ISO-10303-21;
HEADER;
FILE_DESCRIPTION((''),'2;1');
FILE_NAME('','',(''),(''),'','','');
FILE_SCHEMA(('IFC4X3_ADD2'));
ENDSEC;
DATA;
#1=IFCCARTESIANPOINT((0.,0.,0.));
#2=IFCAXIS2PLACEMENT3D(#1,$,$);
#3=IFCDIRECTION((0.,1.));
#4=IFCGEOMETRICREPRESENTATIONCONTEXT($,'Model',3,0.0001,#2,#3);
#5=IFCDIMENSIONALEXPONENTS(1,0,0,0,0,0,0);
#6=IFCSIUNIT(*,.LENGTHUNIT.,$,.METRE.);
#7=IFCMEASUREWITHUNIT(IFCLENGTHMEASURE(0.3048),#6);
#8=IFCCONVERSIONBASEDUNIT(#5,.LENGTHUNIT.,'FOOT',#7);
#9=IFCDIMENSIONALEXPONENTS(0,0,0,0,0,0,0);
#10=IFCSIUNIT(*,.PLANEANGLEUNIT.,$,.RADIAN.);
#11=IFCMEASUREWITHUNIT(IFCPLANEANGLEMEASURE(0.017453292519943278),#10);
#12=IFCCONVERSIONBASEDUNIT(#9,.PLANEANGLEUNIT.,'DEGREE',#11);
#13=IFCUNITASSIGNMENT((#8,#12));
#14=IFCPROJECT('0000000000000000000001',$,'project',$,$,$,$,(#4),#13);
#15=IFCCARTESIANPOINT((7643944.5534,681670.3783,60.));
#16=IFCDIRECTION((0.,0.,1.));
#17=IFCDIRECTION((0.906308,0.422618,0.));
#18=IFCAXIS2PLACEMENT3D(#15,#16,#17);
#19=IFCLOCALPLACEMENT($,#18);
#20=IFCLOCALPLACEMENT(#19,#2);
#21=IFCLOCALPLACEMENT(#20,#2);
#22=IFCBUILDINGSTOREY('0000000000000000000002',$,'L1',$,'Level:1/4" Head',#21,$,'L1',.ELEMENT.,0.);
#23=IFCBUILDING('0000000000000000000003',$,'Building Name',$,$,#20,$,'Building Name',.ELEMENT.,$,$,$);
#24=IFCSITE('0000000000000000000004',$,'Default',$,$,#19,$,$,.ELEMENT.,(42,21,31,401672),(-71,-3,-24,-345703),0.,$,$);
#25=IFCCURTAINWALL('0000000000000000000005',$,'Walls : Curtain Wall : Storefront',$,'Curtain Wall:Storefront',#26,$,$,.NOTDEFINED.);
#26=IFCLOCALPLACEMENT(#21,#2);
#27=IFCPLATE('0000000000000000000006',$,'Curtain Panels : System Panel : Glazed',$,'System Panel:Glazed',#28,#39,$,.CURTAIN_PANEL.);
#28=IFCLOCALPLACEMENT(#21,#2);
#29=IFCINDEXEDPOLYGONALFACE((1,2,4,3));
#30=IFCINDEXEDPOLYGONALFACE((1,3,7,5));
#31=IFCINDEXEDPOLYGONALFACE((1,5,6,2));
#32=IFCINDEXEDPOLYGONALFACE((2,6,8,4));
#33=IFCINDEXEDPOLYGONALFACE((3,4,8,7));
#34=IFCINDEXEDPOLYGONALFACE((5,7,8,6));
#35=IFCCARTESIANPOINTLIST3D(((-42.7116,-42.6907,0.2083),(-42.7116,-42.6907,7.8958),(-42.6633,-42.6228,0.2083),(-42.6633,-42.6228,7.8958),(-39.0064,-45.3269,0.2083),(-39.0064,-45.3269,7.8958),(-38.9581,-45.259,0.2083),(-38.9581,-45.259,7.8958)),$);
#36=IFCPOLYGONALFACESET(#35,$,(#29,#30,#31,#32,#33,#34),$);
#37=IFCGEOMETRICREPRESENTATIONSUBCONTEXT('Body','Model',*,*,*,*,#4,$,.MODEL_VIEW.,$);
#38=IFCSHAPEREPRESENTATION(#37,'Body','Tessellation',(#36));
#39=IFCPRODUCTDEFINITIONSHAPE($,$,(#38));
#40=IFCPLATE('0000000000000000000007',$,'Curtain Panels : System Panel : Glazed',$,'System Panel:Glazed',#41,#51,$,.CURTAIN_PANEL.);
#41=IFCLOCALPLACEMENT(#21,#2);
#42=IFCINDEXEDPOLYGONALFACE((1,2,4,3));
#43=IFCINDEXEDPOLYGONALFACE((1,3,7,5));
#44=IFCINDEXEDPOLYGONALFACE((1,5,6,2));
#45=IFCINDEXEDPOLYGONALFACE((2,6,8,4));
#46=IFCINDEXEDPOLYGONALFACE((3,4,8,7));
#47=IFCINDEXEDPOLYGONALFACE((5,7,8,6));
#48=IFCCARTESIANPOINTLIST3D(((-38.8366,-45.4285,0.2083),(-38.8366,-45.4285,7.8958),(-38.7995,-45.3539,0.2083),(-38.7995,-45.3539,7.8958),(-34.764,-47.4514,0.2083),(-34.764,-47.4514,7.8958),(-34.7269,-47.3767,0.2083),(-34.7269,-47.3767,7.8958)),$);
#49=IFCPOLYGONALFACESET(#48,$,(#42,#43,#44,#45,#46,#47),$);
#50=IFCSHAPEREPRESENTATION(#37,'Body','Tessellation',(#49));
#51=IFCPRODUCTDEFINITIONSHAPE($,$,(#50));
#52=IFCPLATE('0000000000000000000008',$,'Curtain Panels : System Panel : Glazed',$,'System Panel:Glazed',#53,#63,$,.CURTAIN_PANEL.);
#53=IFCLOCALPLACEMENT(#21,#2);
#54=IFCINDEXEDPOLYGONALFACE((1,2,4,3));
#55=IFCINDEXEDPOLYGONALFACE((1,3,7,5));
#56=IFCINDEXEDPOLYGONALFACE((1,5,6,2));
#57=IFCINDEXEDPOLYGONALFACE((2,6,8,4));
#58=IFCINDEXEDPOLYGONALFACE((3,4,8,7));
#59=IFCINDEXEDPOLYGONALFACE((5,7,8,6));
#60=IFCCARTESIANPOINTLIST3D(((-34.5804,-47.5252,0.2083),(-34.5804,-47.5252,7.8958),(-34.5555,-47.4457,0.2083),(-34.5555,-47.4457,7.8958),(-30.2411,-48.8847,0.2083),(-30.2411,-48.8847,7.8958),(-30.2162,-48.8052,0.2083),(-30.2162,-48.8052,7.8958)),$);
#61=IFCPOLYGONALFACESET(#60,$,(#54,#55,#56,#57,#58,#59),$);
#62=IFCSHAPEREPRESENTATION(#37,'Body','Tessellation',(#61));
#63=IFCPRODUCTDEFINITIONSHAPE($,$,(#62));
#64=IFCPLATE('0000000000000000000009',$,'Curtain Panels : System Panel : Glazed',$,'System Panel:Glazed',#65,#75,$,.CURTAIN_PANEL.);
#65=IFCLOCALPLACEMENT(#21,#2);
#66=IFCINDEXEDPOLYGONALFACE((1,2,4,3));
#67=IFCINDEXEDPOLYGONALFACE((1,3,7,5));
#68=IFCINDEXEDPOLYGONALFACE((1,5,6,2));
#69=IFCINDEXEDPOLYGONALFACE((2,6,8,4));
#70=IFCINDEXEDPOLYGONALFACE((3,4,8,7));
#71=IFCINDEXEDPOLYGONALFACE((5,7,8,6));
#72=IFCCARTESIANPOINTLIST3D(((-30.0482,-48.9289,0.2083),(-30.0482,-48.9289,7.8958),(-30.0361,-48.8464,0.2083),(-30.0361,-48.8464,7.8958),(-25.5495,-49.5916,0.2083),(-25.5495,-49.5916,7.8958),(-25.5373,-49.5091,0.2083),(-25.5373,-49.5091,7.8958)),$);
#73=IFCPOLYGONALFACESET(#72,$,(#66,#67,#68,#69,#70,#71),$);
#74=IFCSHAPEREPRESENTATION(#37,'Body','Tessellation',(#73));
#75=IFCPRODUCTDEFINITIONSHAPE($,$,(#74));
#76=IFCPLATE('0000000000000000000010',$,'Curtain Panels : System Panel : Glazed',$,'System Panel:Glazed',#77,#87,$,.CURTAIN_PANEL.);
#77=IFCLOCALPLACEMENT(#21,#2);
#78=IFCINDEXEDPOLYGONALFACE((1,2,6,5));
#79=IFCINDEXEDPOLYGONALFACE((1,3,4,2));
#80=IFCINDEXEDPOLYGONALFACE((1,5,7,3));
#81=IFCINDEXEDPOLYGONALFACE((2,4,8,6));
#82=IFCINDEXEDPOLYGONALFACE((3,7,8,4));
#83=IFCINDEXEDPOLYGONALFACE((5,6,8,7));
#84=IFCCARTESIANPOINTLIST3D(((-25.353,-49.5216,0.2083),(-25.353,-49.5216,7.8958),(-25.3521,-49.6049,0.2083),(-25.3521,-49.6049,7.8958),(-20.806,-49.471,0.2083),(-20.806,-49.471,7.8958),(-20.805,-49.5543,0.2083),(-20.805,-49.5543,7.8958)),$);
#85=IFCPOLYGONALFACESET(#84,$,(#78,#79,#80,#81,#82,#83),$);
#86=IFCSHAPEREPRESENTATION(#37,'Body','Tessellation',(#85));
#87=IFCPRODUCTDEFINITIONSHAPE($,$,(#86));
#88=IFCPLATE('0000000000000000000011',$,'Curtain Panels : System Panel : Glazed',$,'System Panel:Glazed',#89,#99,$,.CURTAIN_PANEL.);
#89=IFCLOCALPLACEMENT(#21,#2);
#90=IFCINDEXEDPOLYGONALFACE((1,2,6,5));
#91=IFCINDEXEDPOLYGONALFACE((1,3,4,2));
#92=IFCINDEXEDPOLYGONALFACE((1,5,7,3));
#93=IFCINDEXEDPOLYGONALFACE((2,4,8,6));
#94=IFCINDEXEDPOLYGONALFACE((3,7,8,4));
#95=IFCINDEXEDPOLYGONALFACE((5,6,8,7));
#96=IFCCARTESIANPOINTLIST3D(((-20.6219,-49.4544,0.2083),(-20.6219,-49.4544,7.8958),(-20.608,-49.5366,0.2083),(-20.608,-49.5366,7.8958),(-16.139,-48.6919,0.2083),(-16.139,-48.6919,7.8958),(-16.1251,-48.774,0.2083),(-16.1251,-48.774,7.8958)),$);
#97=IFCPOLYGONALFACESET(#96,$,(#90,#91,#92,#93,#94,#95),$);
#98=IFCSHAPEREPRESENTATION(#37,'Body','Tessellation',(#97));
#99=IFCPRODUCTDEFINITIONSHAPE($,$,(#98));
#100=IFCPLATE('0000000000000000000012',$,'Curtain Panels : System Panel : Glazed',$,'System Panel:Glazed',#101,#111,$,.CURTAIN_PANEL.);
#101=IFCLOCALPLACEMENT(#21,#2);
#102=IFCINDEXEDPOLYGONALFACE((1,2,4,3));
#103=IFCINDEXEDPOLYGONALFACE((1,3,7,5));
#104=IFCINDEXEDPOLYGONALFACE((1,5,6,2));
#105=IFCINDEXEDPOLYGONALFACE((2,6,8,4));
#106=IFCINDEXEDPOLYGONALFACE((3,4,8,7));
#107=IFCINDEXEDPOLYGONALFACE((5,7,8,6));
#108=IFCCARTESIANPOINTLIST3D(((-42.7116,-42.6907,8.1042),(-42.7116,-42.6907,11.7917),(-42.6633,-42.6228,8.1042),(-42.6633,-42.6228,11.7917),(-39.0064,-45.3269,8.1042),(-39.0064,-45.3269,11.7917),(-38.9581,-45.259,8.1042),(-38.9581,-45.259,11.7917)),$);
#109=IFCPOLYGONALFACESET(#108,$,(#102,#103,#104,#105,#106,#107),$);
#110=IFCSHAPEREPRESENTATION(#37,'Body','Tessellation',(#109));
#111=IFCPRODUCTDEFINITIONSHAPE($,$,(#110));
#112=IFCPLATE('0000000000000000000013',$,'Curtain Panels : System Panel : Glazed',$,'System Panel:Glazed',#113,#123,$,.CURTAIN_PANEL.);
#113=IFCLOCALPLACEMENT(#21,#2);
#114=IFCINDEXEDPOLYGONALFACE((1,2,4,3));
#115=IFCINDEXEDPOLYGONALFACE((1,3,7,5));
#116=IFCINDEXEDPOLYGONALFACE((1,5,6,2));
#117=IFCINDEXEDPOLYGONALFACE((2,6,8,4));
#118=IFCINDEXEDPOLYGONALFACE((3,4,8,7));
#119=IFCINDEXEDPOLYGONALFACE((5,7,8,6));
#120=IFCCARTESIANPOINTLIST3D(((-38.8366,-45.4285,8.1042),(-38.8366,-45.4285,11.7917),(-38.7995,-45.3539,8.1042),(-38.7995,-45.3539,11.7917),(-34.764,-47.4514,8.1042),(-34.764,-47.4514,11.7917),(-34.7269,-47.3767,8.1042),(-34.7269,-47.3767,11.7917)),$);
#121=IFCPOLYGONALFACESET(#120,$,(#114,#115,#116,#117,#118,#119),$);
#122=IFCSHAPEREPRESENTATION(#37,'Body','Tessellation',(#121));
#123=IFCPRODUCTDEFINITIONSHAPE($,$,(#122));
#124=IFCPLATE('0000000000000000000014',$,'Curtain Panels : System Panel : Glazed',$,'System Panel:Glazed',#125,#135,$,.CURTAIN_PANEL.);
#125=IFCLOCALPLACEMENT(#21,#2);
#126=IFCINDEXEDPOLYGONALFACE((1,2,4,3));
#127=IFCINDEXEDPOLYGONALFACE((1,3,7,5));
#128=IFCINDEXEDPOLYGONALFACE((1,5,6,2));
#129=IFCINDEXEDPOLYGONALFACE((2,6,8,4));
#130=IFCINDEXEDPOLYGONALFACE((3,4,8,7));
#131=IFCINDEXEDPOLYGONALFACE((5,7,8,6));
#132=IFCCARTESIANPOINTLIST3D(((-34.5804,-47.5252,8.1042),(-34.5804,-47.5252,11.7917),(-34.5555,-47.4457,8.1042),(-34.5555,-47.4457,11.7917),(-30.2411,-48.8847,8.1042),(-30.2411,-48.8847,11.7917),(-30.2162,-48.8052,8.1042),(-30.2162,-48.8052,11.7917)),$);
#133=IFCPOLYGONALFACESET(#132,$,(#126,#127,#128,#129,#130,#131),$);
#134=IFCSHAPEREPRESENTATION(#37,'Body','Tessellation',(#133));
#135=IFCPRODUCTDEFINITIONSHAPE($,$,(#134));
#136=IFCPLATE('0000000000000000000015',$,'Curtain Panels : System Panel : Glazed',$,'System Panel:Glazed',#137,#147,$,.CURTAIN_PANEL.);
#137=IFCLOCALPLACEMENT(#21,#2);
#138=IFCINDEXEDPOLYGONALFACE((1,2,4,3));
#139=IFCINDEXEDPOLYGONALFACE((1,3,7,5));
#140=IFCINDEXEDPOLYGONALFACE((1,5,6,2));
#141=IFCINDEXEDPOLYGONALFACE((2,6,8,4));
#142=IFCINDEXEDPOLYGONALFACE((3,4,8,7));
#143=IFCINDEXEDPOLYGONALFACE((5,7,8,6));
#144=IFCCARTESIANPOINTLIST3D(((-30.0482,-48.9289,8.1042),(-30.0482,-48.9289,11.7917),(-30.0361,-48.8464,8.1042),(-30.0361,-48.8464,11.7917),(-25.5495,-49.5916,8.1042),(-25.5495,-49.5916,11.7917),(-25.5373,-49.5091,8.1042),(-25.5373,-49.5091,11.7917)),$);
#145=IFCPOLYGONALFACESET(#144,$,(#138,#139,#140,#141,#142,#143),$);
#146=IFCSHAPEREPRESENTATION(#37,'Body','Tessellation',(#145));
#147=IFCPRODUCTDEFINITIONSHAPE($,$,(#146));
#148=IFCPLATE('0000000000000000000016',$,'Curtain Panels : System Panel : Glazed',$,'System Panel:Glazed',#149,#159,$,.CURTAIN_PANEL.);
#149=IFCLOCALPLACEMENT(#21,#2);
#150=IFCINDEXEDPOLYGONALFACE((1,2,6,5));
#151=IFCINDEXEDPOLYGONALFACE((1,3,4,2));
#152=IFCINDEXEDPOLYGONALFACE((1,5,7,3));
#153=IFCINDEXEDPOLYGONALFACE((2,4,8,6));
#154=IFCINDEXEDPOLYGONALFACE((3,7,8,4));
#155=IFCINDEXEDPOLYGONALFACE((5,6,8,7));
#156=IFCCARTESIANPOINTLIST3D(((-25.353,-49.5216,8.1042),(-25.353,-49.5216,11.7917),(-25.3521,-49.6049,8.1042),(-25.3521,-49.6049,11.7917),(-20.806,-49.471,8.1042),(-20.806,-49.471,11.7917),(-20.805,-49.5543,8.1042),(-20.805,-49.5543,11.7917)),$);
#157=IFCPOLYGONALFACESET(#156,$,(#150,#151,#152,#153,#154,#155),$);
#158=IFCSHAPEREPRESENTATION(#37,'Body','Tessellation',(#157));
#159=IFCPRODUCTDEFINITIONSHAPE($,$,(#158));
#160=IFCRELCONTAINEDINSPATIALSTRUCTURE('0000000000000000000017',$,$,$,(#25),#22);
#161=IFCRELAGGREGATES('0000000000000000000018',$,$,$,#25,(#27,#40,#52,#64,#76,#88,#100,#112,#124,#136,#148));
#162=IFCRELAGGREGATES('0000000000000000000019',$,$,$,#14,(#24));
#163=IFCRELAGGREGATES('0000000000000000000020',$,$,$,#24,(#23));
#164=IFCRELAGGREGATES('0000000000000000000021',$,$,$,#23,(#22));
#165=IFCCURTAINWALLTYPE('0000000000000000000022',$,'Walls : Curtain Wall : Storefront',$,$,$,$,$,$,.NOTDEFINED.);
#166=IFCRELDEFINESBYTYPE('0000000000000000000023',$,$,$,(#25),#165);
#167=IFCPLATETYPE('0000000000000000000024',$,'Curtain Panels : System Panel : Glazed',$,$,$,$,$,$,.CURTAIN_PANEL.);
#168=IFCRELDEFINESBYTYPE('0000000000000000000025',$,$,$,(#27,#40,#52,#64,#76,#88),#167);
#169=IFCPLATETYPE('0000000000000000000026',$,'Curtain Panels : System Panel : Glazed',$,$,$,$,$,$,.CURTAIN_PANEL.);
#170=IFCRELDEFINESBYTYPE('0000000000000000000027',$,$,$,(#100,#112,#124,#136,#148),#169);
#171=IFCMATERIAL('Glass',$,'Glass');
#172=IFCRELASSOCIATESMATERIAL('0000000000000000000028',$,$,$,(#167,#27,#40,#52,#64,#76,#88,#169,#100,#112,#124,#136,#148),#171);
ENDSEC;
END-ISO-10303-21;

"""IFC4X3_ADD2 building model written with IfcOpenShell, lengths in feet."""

from ifc_helpers import new_model, entity, si_unit, converted_unit, direction, frame, frame_2d, origin, place, context, subcontext, project, spatial, rectangle, extrude, source, transform, mapped, material, type_object, type_shapes, element, aggregate, save


model = new_model("IFC4X3_ADD2")

# Units and contexts
model_context = context("Model", 3, precision=0.0001, world=origin(), true_north=direction((0.0, 1.0)))
body_context = subcontext(model_context, "Body", "Model", "MODEL_VIEW")
ifc_project = project(units=[converted_unit("LENGTHUNIT", "FOOT", entity("IfcLengthMeasure", 0.3048), si_unit("LENGTHUNIT", "METRE"), dimensions=[1, 0, 0, 0, 0, 0, 0]), converted_unit("PLANEANGLEUNIT", "DEGREE", entity("IfcPlaneAngleMeasure", 0.017453292519943278), si_unit("PLANEANGLEUNIT", "RADIAN"), dimensions=[0, 0, 0, 0, 0, 0, 0])], contexts=[model_context])

# Site, building, storey
site_placement = place(None, frame((7643944.5534, 681670.3783, 60.0), z_axis=(0.0, 0.0, 1.0), x_axis=(0.906308, 0.422618, 0.0)))
site = spatial("IfcSite", under=ifc_project, at=site_placement, Name="Default", CompositionType="ELEMENT", RefLatitude=(42, 21, 31, 401672), RefLongitude=(-71, -3, -24, -345703), RefElevation=0.0)
building_placement = place(site_placement, origin())
building = spatial("IfcBuilding", under=site, at=building_placement, Name="Building Name", LongName="Building Name", CompositionType="ELEMENT")
storey_placement = place(building_placement, origin())
storey = spatial("IfcBuildingStorey", under=building, at=storey_placement, Name="L1", ObjectType="Level:1/4\" Head", LongName="L1", CompositionType="ELEMENT", Elevation=0.0)

# Curtain wall, plates
curtain_wall_type = type_object("IfcCurtainWallType", Name="Walls : Curtain Wall : Storefront", PredefinedType="NOTDEFINED")
curtain_wall_placement = place(storey_placement, origin())
curtain_wall = element("IfcCurtainWall", 1, at=curtain_wall_placement, inside=storey, type_object=curtain_wall_type, Name="Walls : Curtain Wall : Storefront", ObjectType="Curtain Wall:Storefront", PredefinedType="NOTDEFINED")
ifc_material_1 = material(Name="Glass", Category="Glass")
plate_type_1 = type_object("IfcPlateType", Name="Curtain Panels : System Panel : Glazed", PredefinedType="CURTAIN_PANEL", material=ifc_material_1)
shared_shape_1 = source(origin(), body_context, "Body", "SweptSolid", [
    extrude(rectangle(XDim=0.0833, YDim=4.5473, at=frame_2d((0.0, 0.0), x_axis=(1.0, 0.0))), frame((2.2737, 0.0417, 0.0), z_axis=(0.0, 0.0, 1.0), x_axis=(0.0, 1.0, 0.0)), (0.0, 0.0, 1.0), 7.6875),
])
type_shapes(plate_type_1, [shared_shape_1])
plate_1_placement = place(curtain_wall_placement, frame((-42.7116, -42.6907, 0.2083), z_axis=(0.0, 0.0, 1.0), x_axis=(0.814824, -0.579708, 0.0)))
plate_1 = element("IfcPlate", 2, at=plate_1_placement, type_object=plate_type_1, material=ifc_material_1, Name="Curtain Panels : System Panel : Glazed", ObjectType="System Panel:Glazed", PredefinedType="CURTAIN_PANEL", context=body_context, shape_type="MappedRepresentation", body=[
    mapped(shared_shape_1, transform((0.0, 0.0, 0.0), scale=1.0)),
])
plate_2_placement = place(curtain_wall_placement, frame((-38.8366, -45.4285, 0.2083), z_axis=(0.0, 0.0, 1.0), x_axis=(0.895609, -0.444842, 0.0)))
plate_2 = element("IfcPlate", 3, at=plate_2_placement, type_object=plate_type_1, material=ifc_material_1, Name="Curtain Panels : System Panel : Glazed", ObjectType="System Panel:Glazed", PredefinedType="CURTAIN_PANEL", context=body_context, shape_type="MappedRepresentation", body=[
    mapped(shared_shape_1, transform((0.0, 0.0, 0.0), scale=1.0)),
])
plate_3_placement = place(curtain_wall_placement, frame((-34.5804, -47.5252, 0.2083), z_axis=(0.0, 0.0, 1.0), x_axis=(0.954259, -0.298981, 0.0)))
plate_3 = element("IfcPlate", 4, at=plate_3_placement, type_object=plate_type_1, material=ifc_material_1, Name="Curtain Panels : System Panel : Glazed", ObjectType="System Panel:Glazed", PredefinedType="CURTAIN_PANEL", context=body_context, shape_type="MappedRepresentation", body=[
    mapped(shared_shape_1, transform((0.0, 0.0, 0.0), scale=1.0)),
])
plate_4_placement = place(curtain_wall_placement, frame((-30.0482, -48.9289, 0.2083), z_axis=(0.0, 0.0, 1.0), x_axis=(0.989324, -0.145731, 0.0)))
plate_4 = element("IfcPlate", 5, at=plate_4_placement, type_object=plate_type_1, material=ifc_material_1, Name="Curtain Panels : System Panel : Glazed", ObjectType="System Panel:Glazed", PredefinedType="CURTAIN_PANEL", context=body_context, shape_type="MappedRepresentation", body=[
    mapped(shared_shape_1, transform((0.0, 0.0, 0.0), scale=1.0)),
])
plate_5_placement = place(curtain_wall_placement, frame((-25.3521, -49.6049, 0.2083), z_axis=(0.0, 0.0, 1.0), x_axis=(0.999938, 0.011121, 0.0)))
plate_5 = element("IfcPlate", 6, at=plate_5_placement, type_object=plate_type_1, material=ifc_material_1, Name="Curtain Panels : System Panel : Glazed", ObjectType="System Panel:Glazed", PredefinedType="CURTAIN_PANEL", context=body_context, shape_type="MappedRepresentation", body=[
    mapped(shared_shape_1, transform((0.0, 0.0, 0.0), scale=1.0)),
])
plate_6_placement = place(curtain_wall_placement, frame((-20.608, -49.5366, 0.2083), z_axis=(0.0, 0.0, 1.0), x_axis=(0.985838, 0.167698, 0.0)))
plate_6 = element("IfcPlate", 7, at=plate_6_placement, type_object=plate_type_1, material=ifc_material_1, Name="Curtain Panels : System Panel : Glazed", ObjectType="System Panel:Glazed", PredefinedType="CURTAIN_PANEL", context=body_context, shape_type="MappedRepresentation", body=[
    mapped(shared_shape_1, transform((0.0, 0.0, 0.0), scale=1.0)),
])
plate_type_2 = type_object("IfcPlateType", Name="Curtain Panels : System Panel : Glazed", PredefinedType="CURTAIN_PANEL", material=ifc_material_1)
shared_shape_2 = source(origin(), body_context, "Body", "SweptSolid", [
    extrude(rectangle(XDim=0.0833, YDim=4.5473, at=frame_2d((0.0, 0.0), x_axis=(1.0, 0.0))), frame((2.2737, 0.0417, 0.0), z_axis=(0.0, 0.0, 1.0), x_axis=(0.0, 1.0, 0.0)), (0.0, 0.0, 1.0), 3.6875),
])
type_shapes(plate_type_2, [shared_shape_2])
plate_7_placement = place(curtain_wall_placement, frame((-42.7116, -42.6907, 8.1042), z_axis=(0.0, 0.0, 1.0), x_axis=(0.814824, -0.579708, 0.0)))
plate_7 = element("IfcPlate", 8, at=plate_7_placement, type_object=plate_type_2, material=ifc_material_1, Name="Curtain Panels : System Panel : Glazed", ObjectType="System Panel:Glazed", PredefinedType="CURTAIN_PANEL", context=body_context, shape_type="MappedRepresentation", body=[
    mapped(shared_shape_2, transform((0.0, 0.0, 0.0), scale=1.0)),
])
plate_8_placement = place(curtain_wall_placement, frame((-38.8366, -45.4285, 8.1042), z_axis=(0.0, 0.0, 1.0), x_axis=(0.895609, -0.444842, 0.0)))
plate_8 = element("IfcPlate", 9, at=plate_8_placement, type_object=plate_type_2, material=ifc_material_1, Name="Curtain Panels : System Panel : Glazed", ObjectType="System Panel:Glazed", PredefinedType="CURTAIN_PANEL", context=body_context, shape_type="MappedRepresentation", body=[
    mapped(shared_shape_2, transform((0.0, 0.0, 0.0), scale=1.0)),
])
plate_9_placement = place(curtain_wall_placement, frame((-34.5804, -47.5252, 8.1042), z_axis=(0.0, 0.0, 1.0), x_axis=(0.954259, -0.298981, 0.0)))
plate_9 = element("IfcPlate", 10, at=plate_9_placement, type_object=plate_type_2, material=ifc_material_1, Name="Curtain Panels : System Panel : Glazed", ObjectType="System Panel:Glazed", PredefinedType="CURTAIN_PANEL", context=body_context, shape_type="MappedRepresentation", body=[
    mapped(shared_shape_2, transform((0.0, 0.0, 0.0), scale=1.0)),
])
plate_10_placement = place(curtain_wall_placement, frame((-30.0482, -48.9289, 8.1042), z_axis=(0.0, 0.0, 1.0), x_axis=(0.989324, -0.145731, 0.0)))
plate_10 = element("IfcPlate", 11, at=plate_10_placement, type_object=plate_type_2, material=ifc_material_1, Name="Curtain Panels : System Panel : Glazed", ObjectType="System Panel:Glazed", PredefinedType="CURTAIN_PANEL", context=body_context, shape_type="MappedRepresentation", body=[
    mapped(shared_shape_2, transform((0.0, 0.0, 0.0), scale=1.0)),
])
plate_11_placement = place(curtain_wall_placement, frame((-25.3521, -49.6049, 8.1042), z_axis=(0.0, 0.0, 1.0), x_axis=(0.999938, 0.011121, 0.0)))
plate_11 = element("IfcPlate", 12, at=plate_11_placement, type_object=plate_type_2, material=ifc_material_1, Name="Curtain Panels : System Panel : Glazed", ObjectType="System Panel:Glazed", PredefinedType="CURTAIN_PANEL", context=body_context, shape_type="MappedRepresentation", body=[
    mapped(shared_shape_2, transform((0.0, 0.0, 0.0), scale=1.0)),
])
aggregate(curtain_wall, [plate_1, plate_2, plate_3, plate_4, plate_5, plate_6, plate_7, plate_8, plate_9, plate_10, plate_11])

save(model, "model.ifc")
